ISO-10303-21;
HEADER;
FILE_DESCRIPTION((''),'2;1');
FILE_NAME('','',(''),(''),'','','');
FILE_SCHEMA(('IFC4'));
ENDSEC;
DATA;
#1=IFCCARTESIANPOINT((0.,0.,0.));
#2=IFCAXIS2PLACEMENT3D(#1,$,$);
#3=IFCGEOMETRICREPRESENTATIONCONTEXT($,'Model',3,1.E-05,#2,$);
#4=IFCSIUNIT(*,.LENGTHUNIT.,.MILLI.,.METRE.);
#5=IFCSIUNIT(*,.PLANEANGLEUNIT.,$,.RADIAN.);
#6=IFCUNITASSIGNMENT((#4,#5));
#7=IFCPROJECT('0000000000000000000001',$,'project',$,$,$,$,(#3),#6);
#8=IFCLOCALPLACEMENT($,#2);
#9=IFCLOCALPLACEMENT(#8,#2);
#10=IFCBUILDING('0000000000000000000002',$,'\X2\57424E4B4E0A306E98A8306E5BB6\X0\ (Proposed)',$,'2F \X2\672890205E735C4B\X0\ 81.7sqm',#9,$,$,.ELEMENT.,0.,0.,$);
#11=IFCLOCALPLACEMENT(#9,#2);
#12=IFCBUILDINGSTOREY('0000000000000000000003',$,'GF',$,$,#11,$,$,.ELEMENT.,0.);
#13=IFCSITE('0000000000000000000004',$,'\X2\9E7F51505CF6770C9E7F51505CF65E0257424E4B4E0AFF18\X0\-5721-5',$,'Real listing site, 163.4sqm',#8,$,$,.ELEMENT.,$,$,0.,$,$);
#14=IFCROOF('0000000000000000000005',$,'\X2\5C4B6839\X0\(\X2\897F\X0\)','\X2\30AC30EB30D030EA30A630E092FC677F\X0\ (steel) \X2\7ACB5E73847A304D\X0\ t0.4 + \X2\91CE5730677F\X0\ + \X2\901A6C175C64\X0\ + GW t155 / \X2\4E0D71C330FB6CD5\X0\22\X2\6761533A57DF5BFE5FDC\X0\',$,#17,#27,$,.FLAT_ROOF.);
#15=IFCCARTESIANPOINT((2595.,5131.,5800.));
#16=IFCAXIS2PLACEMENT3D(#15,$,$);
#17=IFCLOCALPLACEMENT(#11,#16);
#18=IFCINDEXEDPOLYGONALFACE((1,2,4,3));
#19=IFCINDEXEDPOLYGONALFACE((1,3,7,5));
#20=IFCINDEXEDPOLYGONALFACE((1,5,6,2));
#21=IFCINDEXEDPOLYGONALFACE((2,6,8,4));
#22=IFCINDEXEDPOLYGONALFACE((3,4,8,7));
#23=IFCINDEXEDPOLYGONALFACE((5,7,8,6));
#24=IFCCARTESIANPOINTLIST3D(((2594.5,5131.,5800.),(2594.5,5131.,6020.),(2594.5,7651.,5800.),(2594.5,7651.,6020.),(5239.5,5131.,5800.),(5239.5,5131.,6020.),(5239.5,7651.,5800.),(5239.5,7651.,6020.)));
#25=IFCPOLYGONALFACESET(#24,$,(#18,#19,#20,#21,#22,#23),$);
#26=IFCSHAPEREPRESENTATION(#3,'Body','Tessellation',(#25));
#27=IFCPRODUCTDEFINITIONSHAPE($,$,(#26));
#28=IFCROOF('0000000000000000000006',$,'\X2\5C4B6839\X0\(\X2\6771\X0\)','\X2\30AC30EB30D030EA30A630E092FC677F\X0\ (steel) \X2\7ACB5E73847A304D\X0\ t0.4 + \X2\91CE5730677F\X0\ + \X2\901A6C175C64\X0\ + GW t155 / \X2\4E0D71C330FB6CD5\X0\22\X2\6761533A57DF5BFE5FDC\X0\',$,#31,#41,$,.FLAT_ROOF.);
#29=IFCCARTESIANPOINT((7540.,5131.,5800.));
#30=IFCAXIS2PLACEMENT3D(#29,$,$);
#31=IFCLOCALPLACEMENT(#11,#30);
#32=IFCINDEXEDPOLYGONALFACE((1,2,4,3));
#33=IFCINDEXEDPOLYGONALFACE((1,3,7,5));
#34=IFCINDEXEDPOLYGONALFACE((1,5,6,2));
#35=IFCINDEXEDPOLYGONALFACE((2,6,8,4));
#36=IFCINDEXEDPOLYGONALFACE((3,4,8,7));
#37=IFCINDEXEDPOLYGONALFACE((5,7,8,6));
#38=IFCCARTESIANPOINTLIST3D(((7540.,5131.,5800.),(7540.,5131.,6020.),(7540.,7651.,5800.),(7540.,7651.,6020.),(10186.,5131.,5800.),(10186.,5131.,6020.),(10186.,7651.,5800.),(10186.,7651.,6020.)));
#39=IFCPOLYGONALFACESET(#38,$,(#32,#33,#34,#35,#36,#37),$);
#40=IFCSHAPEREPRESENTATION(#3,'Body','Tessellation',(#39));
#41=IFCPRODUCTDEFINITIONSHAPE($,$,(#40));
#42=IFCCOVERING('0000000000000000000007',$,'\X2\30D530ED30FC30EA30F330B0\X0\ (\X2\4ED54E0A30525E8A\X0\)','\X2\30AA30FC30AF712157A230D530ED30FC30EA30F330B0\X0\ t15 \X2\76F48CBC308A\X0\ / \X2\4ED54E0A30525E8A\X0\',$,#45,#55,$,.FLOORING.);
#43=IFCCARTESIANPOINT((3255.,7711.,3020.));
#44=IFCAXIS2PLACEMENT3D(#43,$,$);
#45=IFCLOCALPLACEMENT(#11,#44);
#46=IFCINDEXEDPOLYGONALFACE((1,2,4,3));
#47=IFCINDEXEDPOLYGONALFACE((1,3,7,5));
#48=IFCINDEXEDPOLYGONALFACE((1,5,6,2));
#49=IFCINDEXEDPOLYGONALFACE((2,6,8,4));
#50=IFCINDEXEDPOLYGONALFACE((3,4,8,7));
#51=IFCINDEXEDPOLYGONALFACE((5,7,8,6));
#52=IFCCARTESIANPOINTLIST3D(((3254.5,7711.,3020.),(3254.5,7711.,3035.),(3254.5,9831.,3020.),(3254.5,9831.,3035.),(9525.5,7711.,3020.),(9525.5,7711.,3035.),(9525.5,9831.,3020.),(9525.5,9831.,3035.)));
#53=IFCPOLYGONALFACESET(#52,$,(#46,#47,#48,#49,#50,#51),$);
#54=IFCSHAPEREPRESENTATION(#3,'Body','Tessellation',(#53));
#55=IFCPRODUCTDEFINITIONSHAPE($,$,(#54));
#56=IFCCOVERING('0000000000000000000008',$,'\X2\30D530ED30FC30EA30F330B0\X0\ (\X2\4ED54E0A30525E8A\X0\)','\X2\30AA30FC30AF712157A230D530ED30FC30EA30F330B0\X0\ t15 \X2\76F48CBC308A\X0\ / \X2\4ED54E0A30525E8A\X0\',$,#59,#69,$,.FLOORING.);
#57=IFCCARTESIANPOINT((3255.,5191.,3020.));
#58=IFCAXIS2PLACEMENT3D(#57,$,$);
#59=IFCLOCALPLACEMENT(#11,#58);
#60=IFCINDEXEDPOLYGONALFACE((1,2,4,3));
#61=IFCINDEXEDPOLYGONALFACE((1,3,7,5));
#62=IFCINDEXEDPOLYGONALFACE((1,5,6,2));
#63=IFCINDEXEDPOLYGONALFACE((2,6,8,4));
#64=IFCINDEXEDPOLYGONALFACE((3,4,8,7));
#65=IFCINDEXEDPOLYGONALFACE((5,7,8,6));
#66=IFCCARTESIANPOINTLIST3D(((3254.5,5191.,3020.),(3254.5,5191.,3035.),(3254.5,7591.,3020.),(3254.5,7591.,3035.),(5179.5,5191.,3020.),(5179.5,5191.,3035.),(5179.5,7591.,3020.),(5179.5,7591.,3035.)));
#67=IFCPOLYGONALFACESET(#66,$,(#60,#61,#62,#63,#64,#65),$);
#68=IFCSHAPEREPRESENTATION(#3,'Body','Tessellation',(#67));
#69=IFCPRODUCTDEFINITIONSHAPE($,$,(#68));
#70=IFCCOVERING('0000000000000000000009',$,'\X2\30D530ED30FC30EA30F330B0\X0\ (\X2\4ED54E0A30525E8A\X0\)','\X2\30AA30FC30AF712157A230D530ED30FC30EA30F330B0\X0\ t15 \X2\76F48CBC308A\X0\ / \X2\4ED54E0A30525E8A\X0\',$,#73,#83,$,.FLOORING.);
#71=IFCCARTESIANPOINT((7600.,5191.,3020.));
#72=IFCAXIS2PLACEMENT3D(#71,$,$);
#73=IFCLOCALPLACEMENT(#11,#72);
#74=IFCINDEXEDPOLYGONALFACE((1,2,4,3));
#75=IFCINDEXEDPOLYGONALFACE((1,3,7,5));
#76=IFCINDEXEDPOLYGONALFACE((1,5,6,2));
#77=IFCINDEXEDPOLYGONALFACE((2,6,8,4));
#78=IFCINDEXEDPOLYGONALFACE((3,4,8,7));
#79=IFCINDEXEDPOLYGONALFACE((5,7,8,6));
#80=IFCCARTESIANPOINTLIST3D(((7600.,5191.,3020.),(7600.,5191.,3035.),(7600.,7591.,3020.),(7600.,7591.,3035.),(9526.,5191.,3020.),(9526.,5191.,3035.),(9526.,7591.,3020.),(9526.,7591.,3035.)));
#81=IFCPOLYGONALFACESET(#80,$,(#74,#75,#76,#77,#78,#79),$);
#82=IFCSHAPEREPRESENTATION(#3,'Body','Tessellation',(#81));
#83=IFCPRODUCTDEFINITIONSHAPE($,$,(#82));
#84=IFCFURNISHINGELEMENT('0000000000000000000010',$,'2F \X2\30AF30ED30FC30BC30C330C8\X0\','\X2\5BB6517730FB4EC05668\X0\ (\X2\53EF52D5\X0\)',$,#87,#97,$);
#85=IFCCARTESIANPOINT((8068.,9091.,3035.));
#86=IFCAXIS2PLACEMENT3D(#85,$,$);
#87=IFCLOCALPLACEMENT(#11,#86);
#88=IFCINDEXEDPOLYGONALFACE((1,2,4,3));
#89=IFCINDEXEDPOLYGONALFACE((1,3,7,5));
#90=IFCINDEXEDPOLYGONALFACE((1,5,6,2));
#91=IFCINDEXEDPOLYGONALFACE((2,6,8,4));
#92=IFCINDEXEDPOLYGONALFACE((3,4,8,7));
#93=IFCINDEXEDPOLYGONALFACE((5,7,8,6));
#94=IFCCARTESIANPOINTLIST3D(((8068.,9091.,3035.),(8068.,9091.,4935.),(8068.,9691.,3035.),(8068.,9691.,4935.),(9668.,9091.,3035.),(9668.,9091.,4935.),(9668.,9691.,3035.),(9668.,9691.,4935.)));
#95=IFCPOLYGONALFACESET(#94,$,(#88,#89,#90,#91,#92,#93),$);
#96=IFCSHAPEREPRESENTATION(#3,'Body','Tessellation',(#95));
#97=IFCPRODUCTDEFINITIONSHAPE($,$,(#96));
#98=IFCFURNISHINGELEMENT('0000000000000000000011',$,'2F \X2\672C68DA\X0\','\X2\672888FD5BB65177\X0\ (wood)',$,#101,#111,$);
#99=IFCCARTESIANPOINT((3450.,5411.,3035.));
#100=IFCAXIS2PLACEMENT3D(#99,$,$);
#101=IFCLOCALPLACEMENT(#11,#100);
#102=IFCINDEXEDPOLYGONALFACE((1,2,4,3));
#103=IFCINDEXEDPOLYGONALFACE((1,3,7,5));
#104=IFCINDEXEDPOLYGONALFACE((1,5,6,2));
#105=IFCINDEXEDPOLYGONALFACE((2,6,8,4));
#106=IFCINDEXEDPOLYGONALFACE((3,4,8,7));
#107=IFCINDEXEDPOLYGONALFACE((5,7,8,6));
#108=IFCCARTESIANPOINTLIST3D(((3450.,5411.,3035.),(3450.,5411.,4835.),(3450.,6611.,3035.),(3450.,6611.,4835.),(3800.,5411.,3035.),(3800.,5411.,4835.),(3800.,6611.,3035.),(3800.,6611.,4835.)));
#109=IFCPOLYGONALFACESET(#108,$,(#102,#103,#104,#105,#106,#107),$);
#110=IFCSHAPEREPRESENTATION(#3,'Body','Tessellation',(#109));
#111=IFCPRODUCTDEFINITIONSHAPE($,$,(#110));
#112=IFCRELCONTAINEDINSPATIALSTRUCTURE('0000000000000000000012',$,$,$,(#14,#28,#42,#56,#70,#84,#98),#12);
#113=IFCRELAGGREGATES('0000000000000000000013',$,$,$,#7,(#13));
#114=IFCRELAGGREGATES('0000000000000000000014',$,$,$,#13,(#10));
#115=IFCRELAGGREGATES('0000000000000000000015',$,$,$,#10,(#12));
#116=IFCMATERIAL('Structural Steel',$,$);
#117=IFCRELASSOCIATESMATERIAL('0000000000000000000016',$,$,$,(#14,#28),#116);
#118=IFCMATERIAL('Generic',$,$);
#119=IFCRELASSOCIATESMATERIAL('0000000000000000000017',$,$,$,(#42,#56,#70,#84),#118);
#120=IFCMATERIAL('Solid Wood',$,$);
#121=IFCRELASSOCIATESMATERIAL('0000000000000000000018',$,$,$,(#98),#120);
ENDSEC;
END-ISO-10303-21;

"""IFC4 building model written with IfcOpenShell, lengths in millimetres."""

from ifc_helpers import new_model, si_unit, frame, frame_2d, origin, place, context, project, spatial, rectangle, extrude, material, element, save


model = new_model("IFC4")

# Units and contexts
model_context = context("Model", 3, precision=1e-05, world=origin())
ifc_project = project(units=[si_unit("LENGTHUNIT", "METRE", prefix="MILLI"), si_unit("PLANEANGLEUNIT", "RADIAN")], contexts=[model_context])

# Site, building, storey
site_placement = place(None, origin())
site = spatial("IfcSite", under=ifc_project, at=site_placement, Name="鹿児島県鹿児島市坂之上８-5721-5", ObjectType="Real listing site, 163.4sqm", CompositionType="ELEMENT", RefElevation=0.0)
building_placement = place(site_placement, origin())
building = spatial("IfcBuilding", under=site, at=building_placement, Name="坂之上の風の家 (Proposed)", ObjectType="2F 木造平屋 81.7sqm", CompositionType="ELEMENT", ElevationOfRefHeight=0.0, ElevationOfTerrain=0.0)
storey_placement = place(building_placement, origin())
storey = spatial("IfcBuildingStorey", under=building, at=storey_placement, Name="GF", CompositionType="ELEMENT", Elevation=0.0)

# Shared definitions
ifc_material_1 = material(Name="Solid Wood")

# Roofs
ifc_material_2 = material(Name="Structural Steel")
roof_1_placement = place(storey_placement, frame((2595.0, 5131.0, 5800.0)))
element("IfcRoof", 1, at=roof_1_placement, inside=storey, material=ifc_material_2, Name="屋根(西)", Description="ガルバリウム鋼板 (steel) 立平葺き t0.4 + 野地板 + 通気層 + GW t155 / 不燃・法22条区域対応", PredefinedType="FLAT_ROOF", context=model_context, shape_type="SweptSolid", body=[
    extrude(rectangle(XDim=2645.0, YDim=2520.0, at=frame_2d((1322.0, 1260.0))), frame((2595.0, 5131.0, 5800.0)), (0.0, 0.0, 1.0), 220.0),
])
roof_2_placement = place(storey_placement, frame((7540.0, 5131.0, 5800.0)))
element("IfcRoof", 2, at=roof_2_placement, inside=storey, material=ifc_material_2, Name="屋根(東)", Description="ガルバリウム鋼板 (steel) 立平葺き t0.4 + 野地板 + 通気層 + GW t155 / 不燃・法22条区域対応", PredefinedType="FLAT_ROOF", context=model_context, shape_type="SweptSolid", body=[
    extrude(rectangle(XDim=2646.0, YDim=2520.0, at=frame_2d((1323.0, 1260.0))), frame((7540.0, 5131.0, 5800.0)), (0.0, 0.0, 1.0), 220.0),
])

# Coverings
ifc_material_3 = material(Name="Generic")
covering_1_placement = place(storey_placement, frame((3255.0, 7711.0, 3020.0)))
element("IfcCovering", 3, at=covering_1_placement, inside=storey, material=ifc_material_3, Name="フローリング (仕上げ床)", Description="オーク無垢フローリング t15 直貼り / 仕上げ床", PredefinedType="FLOORING", context=model_context, shape_type="SweptSolid", body=[
    extrude(rectangle(XDim=6271.0, YDim=2120.0, at=frame_2d((3135.0, 1060.0))), frame((3255.0, 7711.0, 3020.0)), (0.0, 0.0, 1.0), 15.0),
])
covering_2_placement = place(storey_placement, frame((3255.0, 5191.0, 3020.0)))
element("IfcCovering", 4, at=covering_2_placement, inside=storey, material=ifc_material_3, Name="フローリング (仕上げ床)", Description="オーク無垢フローリング t15 直貼り / 仕上げ床", PredefinedType="FLOORING", context=model_context, shape_type="SweptSolid", body=[
    extrude(rectangle(XDim=1925.0, YDim=2400.0, at=frame_2d((962.0, 1200.0))), frame((3255.0, 5191.0, 3020.0)), (0.0, 0.0, 1.0), 15.0),
])
covering_3_placement = place(storey_placement, frame((7600.0, 5191.0, 3020.0)))
element("IfcCovering", 5, at=covering_3_placement, inside=storey, material=ifc_material_3, Name="フローリング (仕上げ床)", Description="オーク無垢フローリング t15 直貼り / 仕上げ床", PredefinedType="FLOORING", context=model_context, shape_type="SweptSolid", body=[
    extrude(rectangle(XDim=1926.0, YDim=2400.0, at=frame_2d((963.0, 1200.0))), frame((7600.0, 5191.0, 3020.0)), (0.0, 0.0, 1.0), 15.0),
])

# Furnishing elements
furnishing_1_placement = place(storey_placement, frame((8068.0, 9091.0, 3035.0)))
element("IfcFurnishingElement", 6, at=furnishing_1_placement, inside=storey, material=ifc_material_3, Name="2F クローゼット", Description="家具・什器 (可動)", context=model_context, shape_type="SweptSolid", body=[
    extrude(rectangle(XDim=1600.0, YDim=600.0, at=frame_2d((800.0, 300.0))), frame((8068.0, 9091.0, 3035.0)), (0.0, 0.0, 1.0), 1900.0),
])
furnishing_2_placement = place(storey_placement, frame((3450.0, 5411.0, 3035.0)))
element("IfcFurnishingElement", 7, at=furnishing_2_placement, inside=storey, material=ifc_material_1, Name="2F 本棚", Description="木製家具 (wood)", context=model_context, shape_type="SweptSolid", body=[
    extrude(rectangle(XDim=350.0, YDim=1200.0, at=frame_2d((175.0, 600.0))), frame((3450.0, 5411.0, 3035.0)), (0.0, 0.0, 1.0), 1800.0),
])

save(model, "model.ifc")
